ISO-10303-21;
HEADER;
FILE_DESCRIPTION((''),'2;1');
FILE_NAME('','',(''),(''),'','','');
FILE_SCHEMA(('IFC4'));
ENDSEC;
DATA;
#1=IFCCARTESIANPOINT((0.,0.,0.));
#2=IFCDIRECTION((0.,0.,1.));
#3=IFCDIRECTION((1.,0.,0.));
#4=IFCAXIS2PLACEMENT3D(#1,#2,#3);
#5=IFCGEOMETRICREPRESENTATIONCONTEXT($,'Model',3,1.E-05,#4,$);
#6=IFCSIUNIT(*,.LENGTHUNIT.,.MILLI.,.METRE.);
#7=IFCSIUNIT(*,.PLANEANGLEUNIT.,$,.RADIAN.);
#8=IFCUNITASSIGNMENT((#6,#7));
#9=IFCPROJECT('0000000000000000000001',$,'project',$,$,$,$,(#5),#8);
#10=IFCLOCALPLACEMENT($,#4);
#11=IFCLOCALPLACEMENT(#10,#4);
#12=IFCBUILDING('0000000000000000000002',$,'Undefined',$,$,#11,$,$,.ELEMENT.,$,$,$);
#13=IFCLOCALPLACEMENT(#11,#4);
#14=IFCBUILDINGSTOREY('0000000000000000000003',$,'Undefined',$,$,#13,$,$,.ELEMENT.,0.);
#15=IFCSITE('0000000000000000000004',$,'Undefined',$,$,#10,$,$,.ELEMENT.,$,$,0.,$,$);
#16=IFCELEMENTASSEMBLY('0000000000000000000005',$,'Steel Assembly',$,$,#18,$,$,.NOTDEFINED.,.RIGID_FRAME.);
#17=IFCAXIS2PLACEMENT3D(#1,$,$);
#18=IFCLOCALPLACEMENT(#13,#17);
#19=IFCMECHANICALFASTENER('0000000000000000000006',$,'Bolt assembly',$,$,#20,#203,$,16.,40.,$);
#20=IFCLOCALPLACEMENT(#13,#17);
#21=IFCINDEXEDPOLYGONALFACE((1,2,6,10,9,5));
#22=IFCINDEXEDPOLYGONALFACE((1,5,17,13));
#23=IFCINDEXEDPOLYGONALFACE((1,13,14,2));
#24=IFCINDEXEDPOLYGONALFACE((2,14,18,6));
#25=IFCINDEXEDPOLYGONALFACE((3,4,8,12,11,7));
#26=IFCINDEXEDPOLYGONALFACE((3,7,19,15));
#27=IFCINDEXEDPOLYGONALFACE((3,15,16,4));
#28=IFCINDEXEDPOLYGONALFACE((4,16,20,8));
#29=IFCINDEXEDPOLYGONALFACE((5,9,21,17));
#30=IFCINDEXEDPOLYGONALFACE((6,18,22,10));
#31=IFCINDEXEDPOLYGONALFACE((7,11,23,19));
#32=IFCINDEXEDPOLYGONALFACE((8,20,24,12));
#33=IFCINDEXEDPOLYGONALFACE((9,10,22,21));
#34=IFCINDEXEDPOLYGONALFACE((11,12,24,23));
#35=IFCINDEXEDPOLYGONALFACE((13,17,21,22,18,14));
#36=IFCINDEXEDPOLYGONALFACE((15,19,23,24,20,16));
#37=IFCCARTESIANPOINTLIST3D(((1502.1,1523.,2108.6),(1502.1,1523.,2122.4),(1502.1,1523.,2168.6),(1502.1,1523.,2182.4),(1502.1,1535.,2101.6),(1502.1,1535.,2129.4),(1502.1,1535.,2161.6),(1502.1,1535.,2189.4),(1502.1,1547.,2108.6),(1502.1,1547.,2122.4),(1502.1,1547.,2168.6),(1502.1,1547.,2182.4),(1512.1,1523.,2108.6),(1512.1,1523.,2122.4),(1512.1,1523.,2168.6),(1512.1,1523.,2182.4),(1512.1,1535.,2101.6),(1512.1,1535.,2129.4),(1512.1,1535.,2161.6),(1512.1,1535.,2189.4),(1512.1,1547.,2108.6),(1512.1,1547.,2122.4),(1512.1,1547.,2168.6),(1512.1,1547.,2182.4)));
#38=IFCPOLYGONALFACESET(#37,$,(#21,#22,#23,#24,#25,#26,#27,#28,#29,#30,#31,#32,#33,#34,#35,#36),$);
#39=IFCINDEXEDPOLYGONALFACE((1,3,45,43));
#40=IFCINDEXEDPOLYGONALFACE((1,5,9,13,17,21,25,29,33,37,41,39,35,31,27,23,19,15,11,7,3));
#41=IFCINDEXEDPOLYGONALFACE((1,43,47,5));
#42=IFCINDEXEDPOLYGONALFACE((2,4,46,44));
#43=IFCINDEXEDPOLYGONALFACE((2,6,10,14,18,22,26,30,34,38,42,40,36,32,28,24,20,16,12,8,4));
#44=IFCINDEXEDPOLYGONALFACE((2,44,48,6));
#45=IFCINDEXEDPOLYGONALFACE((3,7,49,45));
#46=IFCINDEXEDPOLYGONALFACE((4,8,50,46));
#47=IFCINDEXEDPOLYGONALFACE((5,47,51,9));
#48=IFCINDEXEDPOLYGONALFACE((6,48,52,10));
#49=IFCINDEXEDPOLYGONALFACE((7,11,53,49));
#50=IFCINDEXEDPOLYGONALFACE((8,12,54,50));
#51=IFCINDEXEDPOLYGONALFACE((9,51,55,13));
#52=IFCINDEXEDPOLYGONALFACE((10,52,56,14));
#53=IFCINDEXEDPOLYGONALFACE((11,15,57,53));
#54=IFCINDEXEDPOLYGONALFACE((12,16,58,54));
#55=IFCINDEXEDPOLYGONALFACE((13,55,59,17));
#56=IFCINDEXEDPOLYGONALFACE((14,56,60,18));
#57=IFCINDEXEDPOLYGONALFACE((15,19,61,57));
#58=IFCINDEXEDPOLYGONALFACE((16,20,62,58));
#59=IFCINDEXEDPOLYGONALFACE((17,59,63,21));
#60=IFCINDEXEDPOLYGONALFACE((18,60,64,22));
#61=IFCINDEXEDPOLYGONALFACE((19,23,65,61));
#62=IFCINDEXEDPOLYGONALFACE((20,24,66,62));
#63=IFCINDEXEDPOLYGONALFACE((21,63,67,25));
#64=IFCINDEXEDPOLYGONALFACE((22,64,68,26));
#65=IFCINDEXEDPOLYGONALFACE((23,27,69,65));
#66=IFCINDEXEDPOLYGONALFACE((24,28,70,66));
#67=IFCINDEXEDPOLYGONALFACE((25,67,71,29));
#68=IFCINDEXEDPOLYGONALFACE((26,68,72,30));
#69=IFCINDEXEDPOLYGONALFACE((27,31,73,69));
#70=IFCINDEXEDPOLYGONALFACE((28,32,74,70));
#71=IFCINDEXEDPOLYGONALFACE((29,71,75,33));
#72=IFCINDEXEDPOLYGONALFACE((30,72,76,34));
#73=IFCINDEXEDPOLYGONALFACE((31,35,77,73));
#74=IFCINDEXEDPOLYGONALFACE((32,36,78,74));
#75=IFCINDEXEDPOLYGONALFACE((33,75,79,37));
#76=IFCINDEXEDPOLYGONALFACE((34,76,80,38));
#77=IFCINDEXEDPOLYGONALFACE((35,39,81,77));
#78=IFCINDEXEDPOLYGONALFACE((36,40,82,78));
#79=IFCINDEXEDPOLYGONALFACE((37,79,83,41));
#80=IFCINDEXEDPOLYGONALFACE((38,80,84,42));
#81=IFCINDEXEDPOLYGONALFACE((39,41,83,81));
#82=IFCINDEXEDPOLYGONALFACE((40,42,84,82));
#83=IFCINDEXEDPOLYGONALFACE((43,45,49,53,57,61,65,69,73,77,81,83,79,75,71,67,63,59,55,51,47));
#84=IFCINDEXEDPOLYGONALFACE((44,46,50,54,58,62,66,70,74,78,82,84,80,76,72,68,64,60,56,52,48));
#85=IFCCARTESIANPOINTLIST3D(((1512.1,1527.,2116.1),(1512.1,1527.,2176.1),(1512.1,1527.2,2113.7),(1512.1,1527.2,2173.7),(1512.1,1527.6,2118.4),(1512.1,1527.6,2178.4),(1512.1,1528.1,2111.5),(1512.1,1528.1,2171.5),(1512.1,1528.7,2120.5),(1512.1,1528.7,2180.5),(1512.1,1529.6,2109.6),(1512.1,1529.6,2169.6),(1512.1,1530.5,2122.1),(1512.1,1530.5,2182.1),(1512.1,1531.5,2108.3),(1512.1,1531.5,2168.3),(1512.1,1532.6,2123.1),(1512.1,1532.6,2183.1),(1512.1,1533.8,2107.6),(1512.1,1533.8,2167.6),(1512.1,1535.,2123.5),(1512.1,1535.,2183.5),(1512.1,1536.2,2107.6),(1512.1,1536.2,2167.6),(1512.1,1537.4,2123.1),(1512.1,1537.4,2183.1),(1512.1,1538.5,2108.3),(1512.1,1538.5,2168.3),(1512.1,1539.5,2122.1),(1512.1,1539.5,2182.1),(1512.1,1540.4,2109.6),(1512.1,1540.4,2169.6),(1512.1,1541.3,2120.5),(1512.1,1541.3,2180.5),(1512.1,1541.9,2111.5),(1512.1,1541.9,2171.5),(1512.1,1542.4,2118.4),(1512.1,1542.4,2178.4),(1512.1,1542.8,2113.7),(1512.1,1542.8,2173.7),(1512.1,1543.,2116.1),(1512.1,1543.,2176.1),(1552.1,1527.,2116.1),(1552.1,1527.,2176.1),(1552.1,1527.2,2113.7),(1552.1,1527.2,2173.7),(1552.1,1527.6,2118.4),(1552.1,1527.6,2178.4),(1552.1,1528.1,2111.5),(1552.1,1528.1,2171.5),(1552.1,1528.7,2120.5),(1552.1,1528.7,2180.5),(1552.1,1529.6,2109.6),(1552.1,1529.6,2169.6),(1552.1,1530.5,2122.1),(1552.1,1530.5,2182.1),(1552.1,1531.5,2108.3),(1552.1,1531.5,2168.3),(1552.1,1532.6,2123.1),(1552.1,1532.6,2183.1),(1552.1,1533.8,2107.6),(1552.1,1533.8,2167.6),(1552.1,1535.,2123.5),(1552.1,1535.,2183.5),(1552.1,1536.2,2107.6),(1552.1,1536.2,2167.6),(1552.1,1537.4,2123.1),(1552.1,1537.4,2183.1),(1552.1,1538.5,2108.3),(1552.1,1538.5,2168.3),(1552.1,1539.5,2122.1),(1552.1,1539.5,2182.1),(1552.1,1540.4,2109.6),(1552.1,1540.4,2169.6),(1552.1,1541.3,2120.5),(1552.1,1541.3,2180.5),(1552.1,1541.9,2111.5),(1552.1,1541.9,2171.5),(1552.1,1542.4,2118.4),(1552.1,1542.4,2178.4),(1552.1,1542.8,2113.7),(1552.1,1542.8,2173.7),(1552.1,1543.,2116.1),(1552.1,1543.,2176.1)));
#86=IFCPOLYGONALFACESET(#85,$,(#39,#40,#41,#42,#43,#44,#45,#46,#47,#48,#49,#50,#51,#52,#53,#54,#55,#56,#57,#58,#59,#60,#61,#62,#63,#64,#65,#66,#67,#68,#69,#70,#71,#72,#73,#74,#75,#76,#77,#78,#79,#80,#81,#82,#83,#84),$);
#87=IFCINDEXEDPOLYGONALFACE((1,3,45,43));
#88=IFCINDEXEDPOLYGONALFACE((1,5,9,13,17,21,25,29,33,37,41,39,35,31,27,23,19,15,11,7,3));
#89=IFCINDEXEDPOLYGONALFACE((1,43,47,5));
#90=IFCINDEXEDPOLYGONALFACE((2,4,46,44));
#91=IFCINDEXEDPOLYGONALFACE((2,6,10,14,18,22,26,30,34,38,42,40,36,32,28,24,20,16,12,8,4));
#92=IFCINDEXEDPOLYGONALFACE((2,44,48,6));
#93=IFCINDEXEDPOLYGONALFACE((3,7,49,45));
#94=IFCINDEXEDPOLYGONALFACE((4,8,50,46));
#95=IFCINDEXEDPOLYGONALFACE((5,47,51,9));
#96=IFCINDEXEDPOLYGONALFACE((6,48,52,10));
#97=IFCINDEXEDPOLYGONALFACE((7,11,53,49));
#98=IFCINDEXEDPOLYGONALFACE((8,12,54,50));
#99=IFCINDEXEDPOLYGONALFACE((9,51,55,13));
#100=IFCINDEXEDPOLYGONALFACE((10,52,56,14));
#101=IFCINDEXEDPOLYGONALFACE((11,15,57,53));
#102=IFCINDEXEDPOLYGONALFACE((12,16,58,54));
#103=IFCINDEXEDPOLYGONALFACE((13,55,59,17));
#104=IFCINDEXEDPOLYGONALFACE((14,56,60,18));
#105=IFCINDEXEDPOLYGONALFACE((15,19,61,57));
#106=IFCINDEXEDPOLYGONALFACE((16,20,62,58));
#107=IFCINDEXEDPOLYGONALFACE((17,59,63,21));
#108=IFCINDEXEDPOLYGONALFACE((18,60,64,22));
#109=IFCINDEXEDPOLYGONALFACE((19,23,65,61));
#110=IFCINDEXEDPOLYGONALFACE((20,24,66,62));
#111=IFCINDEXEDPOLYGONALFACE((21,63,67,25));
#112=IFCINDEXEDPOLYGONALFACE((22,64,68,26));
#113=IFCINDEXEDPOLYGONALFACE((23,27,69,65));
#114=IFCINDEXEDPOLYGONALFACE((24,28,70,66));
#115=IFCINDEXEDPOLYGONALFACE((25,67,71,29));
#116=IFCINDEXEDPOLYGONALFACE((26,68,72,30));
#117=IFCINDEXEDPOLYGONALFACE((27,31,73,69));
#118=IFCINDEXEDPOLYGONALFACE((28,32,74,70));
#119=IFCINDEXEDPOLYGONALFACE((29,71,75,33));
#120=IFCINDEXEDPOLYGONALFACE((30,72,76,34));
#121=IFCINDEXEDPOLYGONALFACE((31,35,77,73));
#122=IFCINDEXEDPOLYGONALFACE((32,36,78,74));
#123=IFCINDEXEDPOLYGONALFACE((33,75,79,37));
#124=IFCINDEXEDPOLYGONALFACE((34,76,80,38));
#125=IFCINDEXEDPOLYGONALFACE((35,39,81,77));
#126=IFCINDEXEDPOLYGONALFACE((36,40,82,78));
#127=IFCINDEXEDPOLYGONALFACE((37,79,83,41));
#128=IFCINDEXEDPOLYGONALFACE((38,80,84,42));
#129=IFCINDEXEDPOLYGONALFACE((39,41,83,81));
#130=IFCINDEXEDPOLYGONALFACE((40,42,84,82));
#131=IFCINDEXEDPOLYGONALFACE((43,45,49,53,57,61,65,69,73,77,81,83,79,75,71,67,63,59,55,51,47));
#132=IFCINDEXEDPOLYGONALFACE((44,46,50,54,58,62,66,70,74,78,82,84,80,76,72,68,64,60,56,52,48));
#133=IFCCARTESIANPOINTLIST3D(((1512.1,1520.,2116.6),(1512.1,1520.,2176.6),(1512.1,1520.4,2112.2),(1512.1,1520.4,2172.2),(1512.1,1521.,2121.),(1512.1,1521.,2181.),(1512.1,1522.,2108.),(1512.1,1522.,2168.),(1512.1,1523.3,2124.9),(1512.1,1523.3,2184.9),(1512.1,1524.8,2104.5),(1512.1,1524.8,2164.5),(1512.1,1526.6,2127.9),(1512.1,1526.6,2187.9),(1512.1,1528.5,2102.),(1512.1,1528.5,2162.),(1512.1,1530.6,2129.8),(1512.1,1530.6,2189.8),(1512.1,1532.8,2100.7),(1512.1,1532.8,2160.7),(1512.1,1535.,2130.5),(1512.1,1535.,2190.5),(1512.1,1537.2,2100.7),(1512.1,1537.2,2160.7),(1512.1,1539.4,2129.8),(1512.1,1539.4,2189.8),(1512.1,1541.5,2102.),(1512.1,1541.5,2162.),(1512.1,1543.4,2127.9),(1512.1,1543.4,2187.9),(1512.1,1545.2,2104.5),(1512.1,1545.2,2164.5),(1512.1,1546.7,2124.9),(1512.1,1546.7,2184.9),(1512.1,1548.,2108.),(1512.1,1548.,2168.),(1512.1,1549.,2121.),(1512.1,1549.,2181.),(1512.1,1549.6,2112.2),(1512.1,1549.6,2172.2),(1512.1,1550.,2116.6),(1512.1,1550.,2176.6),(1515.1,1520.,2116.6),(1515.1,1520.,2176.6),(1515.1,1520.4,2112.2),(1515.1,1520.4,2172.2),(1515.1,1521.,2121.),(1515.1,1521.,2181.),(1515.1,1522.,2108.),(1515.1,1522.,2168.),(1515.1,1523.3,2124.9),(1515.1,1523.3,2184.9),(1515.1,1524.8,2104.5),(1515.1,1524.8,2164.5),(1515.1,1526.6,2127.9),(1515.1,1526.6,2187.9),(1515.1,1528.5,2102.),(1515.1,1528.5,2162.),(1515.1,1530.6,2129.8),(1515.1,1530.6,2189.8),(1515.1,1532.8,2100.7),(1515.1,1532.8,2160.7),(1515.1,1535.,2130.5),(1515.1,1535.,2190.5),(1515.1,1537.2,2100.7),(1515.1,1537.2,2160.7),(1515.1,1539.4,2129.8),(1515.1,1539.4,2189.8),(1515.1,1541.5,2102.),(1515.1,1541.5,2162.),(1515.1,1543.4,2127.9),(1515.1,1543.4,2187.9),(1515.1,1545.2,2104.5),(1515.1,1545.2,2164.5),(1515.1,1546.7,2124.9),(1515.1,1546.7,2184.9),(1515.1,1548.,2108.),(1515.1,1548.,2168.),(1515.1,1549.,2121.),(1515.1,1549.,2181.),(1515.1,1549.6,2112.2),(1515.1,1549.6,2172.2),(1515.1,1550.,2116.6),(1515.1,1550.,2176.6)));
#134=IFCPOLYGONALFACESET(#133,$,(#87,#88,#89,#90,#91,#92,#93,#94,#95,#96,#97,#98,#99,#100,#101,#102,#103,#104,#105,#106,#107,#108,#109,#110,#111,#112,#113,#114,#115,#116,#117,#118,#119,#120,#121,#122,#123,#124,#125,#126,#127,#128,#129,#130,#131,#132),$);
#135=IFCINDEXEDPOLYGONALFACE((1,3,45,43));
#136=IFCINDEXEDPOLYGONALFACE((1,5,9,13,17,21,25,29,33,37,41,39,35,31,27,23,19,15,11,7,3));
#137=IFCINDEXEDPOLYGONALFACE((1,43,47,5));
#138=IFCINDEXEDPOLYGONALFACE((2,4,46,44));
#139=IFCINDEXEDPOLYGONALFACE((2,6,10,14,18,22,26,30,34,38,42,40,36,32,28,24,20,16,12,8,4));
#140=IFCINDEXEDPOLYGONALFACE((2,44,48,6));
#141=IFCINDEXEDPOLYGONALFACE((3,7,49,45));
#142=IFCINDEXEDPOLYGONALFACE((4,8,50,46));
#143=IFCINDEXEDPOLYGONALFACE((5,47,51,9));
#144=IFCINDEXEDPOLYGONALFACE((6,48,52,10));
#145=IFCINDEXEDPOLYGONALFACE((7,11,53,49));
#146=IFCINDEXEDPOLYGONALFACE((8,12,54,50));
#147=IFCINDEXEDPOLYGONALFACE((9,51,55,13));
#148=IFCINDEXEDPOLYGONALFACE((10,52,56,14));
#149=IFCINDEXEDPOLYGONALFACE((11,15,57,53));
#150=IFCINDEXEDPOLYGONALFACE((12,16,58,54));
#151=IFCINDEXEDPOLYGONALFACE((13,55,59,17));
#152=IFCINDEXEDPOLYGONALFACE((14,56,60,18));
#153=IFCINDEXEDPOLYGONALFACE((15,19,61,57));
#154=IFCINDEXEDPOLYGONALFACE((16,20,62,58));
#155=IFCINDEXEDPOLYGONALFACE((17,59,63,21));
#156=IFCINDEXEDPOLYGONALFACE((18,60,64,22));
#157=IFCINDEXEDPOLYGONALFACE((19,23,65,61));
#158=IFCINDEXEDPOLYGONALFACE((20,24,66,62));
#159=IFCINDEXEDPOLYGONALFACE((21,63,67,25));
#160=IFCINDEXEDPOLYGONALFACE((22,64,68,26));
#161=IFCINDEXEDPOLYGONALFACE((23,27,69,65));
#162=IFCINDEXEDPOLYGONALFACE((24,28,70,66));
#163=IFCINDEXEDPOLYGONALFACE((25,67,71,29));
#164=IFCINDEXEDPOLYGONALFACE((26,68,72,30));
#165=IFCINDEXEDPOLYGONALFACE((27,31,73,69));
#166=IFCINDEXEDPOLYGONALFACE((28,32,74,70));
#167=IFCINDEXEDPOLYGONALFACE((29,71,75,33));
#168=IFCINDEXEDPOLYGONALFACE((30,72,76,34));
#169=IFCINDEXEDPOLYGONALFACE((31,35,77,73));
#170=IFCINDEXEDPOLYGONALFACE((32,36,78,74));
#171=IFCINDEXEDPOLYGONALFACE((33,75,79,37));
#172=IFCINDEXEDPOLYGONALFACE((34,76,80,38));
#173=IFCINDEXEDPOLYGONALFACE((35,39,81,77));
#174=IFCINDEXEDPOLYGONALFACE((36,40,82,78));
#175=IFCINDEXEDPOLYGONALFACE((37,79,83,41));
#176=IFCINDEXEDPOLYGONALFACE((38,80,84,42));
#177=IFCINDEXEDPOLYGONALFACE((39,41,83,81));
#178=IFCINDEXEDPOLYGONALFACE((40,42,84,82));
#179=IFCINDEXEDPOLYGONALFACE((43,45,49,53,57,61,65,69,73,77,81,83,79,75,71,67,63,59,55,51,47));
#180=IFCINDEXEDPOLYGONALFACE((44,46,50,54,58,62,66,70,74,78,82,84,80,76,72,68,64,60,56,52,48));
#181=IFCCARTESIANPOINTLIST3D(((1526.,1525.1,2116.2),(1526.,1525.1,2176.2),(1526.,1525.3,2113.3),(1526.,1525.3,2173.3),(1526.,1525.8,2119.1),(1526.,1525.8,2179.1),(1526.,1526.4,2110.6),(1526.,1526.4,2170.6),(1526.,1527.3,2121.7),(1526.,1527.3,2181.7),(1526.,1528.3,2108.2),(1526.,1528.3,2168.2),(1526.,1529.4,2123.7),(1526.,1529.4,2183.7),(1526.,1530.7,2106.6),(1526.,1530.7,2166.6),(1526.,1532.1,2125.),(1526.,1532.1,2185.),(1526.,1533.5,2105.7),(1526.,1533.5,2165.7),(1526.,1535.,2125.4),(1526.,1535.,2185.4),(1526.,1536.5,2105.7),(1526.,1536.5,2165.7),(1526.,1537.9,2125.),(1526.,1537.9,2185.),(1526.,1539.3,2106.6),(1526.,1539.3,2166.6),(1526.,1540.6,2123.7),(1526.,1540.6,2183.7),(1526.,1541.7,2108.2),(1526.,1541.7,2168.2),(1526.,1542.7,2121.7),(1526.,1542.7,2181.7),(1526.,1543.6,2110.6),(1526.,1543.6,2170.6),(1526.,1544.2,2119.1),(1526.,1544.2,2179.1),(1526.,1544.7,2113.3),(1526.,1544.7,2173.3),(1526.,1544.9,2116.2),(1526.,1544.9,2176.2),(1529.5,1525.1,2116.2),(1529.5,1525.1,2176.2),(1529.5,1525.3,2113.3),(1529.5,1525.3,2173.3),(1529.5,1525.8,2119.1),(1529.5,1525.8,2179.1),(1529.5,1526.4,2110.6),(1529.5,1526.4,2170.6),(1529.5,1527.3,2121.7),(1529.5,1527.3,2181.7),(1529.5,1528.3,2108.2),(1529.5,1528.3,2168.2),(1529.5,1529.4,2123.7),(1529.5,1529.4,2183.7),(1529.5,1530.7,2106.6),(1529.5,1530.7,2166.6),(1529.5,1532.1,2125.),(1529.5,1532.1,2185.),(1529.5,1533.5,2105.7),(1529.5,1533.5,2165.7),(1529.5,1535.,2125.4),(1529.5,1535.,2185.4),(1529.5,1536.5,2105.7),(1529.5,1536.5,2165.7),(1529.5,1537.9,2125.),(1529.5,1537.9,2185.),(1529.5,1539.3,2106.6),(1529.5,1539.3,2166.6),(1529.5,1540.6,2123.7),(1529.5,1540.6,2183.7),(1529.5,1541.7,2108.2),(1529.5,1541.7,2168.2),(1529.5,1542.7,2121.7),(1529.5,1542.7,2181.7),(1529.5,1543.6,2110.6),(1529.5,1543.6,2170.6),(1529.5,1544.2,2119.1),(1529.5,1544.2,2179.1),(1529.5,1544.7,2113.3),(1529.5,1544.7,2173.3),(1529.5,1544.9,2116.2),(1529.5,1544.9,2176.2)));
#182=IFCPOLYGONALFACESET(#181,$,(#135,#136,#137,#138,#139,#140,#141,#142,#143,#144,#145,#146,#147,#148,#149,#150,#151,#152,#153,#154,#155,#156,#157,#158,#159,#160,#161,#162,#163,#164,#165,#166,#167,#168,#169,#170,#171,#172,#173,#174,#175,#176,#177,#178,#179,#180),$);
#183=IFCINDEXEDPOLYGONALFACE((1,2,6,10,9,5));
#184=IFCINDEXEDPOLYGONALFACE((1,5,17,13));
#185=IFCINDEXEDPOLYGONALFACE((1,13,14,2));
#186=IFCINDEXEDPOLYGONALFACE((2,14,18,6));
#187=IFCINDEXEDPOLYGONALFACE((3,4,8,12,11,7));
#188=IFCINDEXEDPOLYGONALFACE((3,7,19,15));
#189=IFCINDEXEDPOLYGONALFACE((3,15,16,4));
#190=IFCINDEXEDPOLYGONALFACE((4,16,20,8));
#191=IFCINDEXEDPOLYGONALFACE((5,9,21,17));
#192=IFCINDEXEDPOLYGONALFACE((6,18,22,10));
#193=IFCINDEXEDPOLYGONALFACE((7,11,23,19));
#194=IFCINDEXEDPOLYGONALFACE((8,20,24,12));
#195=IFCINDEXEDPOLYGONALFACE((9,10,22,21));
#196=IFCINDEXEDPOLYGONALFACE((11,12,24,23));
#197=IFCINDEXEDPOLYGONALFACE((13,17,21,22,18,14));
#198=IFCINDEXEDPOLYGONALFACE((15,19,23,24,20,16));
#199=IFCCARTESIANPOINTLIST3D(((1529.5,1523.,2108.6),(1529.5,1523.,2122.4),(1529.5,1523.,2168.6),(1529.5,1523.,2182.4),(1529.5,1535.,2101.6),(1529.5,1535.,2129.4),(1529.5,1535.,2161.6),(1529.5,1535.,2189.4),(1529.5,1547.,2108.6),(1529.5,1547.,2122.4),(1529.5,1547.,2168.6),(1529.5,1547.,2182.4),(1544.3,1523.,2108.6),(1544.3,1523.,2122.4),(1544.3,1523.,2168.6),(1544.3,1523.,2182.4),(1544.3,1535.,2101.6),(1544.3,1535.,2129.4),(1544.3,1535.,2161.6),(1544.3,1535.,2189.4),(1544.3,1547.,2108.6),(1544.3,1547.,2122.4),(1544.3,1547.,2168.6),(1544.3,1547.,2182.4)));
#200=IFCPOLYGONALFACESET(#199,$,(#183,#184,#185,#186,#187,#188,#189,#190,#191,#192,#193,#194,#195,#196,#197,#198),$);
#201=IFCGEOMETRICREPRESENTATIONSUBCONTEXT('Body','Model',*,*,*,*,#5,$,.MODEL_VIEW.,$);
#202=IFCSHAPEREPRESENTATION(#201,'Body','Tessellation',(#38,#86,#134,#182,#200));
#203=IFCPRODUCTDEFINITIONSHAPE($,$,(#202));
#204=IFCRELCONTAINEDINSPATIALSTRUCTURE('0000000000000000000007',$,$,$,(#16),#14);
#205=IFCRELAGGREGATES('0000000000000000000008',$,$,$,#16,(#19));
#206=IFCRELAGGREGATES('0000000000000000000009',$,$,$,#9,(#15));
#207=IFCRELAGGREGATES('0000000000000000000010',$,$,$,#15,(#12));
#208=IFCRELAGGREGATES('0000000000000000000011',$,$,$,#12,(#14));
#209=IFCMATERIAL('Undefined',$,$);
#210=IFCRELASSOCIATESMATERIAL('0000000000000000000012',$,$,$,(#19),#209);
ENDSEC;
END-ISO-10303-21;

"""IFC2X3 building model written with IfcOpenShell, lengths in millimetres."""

from ifc_helpers import new_model, si_unit, frame, origin_with_axes, origin_2d_with_axis, place, context, subcontext, project, spatial, polyline, circle, outline, extrude, source, transform, mapped, material, element, aggregate, save


model = new_model("IFC2X3")

# Units and contexts
model_context = context("Model", 3, precision=1e-05, world=origin_with_axes())
body_context = subcontext(model_context, "Body", "Model", "MODEL_VIEW")
ifc_project = project(units=[si_unit("LENGTHUNIT", "METRE", prefix="MILLI"), si_unit("PLANEANGLEUNIT", "RADIAN")], contexts=[model_context])

# Site, building, storey
site_placement = place(None, origin_with_axes())
site = spatial("IfcSite", under=ifc_project, at=site_placement, Name="Undefined", CompositionType="ELEMENT", RefElevation=0.0)
building_placement = place(site_placement, origin_with_axes())
building = spatial("IfcBuilding", under=site, at=building_placement, Name="Undefined", CompositionType="ELEMENT")
storey_placement = place(building_placement, origin_with_axes())
storey = spatial("IfcBuildingStorey", under=building, at=storey_placement, Name="Undefined", CompositionType="ELEMENT", Elevation=0.0)

# Element assembly, mechanical fastener
assembly_1_placement = place(storey_placement, origin_with_axes())
assembly_1 = element("IfcElementAssembly", 1, at=assembly_1_placement, inside=storey, Name="Steel Assembly", AssemblyPlace="NOTDEFINED", PredefinedType="RIGID_FRAME")
ifc_material_1 = material(Name="Undefined")
shared_shape_1 = source(origin_with_axes(), body_context, "Body", "SweptSolid", [
    extrude(outline(polyline([(13.9, 0.0), (6.9, 12.0), (-6.9, 12.0), (-13.9, 0.0), (-6.9, -12.0), (6.9, -12.0), (13.9, 0.0)])), frame((0.0, -17.9, 0.0), z_axis=(0.0, 1.0, 0.0), x_axis=(1.0, 0.0, 0.0)), (0.0, 0.0, 1.0), 10.0),
    extrude(circle(Radius=8.0, at=origin_2d_with_axis()), frame((0.0, -7.9, 0.0), z_axis=(0.0, 1.0, 0.0), x_axis=(1.0, 0.0, 0.0)), (0.0, 0.0, 1.0), 40.0),
    extrude(circle(Radius=15.0, at=origin_2d_with_axis()), frame((0.0, -7.9, 0.0), z_axis=(0.0, 1.0, 0.0), x_axis=(1.0, 0.0, 0.0)), (0.0, 0.0, 1.0), 3.0),
    extrude(circle(Radius=9.9, at=origin_2d_with_axis()), frame((0.0, 6.0, 0.0), z_axis=(0.0, 1.0, 0.0), x_axis=(1.0, 0.0, 0.0)), (0.0, 0.0, 1.0), 3.5),
    extrude(outline(polyline([(13.9, 0.0), (6.9, 12.0), (-6.9, 12.0), (-13.9, 0.0), (-6.9, -12.0), (6.9, -12.0), (13.9, 0.0)])), frame((0.0, 9.5, 0.0), z_axis=(0.0, 1.0, 0.0), x_axis=(1.0, 0.0, 0.0)), (0.0, 0.0, 1.0), 14.8),
])
mechanical_fastener_1_placement = place(assembly_1_placement, frame((1520.0, 1535.0, 2115.5), z_axis=(0.0, 1.0, 0.0), x_axis=(0.0, 0.0, 1.0)))
mechanical_fastener_1 = element("IfcMechanicalFastener", 2, at=mechanical_fastener_1_placement, material=ifc_material_1, Name="Bolt assembly", NominalDiameter=16.0, NominalLength=40.0, context=body_context, shape_type="MappedRepresentation", body=[
    mapped(shared_shape_1, transform((0.0, 0.0, 0.0))),
    mapped(shared_shape_1, transform((60.0, 0.0, 0.0))),
])
aggregate(assembly_1, [mechanical_fastener_1])

save(model, "model.ifc")
